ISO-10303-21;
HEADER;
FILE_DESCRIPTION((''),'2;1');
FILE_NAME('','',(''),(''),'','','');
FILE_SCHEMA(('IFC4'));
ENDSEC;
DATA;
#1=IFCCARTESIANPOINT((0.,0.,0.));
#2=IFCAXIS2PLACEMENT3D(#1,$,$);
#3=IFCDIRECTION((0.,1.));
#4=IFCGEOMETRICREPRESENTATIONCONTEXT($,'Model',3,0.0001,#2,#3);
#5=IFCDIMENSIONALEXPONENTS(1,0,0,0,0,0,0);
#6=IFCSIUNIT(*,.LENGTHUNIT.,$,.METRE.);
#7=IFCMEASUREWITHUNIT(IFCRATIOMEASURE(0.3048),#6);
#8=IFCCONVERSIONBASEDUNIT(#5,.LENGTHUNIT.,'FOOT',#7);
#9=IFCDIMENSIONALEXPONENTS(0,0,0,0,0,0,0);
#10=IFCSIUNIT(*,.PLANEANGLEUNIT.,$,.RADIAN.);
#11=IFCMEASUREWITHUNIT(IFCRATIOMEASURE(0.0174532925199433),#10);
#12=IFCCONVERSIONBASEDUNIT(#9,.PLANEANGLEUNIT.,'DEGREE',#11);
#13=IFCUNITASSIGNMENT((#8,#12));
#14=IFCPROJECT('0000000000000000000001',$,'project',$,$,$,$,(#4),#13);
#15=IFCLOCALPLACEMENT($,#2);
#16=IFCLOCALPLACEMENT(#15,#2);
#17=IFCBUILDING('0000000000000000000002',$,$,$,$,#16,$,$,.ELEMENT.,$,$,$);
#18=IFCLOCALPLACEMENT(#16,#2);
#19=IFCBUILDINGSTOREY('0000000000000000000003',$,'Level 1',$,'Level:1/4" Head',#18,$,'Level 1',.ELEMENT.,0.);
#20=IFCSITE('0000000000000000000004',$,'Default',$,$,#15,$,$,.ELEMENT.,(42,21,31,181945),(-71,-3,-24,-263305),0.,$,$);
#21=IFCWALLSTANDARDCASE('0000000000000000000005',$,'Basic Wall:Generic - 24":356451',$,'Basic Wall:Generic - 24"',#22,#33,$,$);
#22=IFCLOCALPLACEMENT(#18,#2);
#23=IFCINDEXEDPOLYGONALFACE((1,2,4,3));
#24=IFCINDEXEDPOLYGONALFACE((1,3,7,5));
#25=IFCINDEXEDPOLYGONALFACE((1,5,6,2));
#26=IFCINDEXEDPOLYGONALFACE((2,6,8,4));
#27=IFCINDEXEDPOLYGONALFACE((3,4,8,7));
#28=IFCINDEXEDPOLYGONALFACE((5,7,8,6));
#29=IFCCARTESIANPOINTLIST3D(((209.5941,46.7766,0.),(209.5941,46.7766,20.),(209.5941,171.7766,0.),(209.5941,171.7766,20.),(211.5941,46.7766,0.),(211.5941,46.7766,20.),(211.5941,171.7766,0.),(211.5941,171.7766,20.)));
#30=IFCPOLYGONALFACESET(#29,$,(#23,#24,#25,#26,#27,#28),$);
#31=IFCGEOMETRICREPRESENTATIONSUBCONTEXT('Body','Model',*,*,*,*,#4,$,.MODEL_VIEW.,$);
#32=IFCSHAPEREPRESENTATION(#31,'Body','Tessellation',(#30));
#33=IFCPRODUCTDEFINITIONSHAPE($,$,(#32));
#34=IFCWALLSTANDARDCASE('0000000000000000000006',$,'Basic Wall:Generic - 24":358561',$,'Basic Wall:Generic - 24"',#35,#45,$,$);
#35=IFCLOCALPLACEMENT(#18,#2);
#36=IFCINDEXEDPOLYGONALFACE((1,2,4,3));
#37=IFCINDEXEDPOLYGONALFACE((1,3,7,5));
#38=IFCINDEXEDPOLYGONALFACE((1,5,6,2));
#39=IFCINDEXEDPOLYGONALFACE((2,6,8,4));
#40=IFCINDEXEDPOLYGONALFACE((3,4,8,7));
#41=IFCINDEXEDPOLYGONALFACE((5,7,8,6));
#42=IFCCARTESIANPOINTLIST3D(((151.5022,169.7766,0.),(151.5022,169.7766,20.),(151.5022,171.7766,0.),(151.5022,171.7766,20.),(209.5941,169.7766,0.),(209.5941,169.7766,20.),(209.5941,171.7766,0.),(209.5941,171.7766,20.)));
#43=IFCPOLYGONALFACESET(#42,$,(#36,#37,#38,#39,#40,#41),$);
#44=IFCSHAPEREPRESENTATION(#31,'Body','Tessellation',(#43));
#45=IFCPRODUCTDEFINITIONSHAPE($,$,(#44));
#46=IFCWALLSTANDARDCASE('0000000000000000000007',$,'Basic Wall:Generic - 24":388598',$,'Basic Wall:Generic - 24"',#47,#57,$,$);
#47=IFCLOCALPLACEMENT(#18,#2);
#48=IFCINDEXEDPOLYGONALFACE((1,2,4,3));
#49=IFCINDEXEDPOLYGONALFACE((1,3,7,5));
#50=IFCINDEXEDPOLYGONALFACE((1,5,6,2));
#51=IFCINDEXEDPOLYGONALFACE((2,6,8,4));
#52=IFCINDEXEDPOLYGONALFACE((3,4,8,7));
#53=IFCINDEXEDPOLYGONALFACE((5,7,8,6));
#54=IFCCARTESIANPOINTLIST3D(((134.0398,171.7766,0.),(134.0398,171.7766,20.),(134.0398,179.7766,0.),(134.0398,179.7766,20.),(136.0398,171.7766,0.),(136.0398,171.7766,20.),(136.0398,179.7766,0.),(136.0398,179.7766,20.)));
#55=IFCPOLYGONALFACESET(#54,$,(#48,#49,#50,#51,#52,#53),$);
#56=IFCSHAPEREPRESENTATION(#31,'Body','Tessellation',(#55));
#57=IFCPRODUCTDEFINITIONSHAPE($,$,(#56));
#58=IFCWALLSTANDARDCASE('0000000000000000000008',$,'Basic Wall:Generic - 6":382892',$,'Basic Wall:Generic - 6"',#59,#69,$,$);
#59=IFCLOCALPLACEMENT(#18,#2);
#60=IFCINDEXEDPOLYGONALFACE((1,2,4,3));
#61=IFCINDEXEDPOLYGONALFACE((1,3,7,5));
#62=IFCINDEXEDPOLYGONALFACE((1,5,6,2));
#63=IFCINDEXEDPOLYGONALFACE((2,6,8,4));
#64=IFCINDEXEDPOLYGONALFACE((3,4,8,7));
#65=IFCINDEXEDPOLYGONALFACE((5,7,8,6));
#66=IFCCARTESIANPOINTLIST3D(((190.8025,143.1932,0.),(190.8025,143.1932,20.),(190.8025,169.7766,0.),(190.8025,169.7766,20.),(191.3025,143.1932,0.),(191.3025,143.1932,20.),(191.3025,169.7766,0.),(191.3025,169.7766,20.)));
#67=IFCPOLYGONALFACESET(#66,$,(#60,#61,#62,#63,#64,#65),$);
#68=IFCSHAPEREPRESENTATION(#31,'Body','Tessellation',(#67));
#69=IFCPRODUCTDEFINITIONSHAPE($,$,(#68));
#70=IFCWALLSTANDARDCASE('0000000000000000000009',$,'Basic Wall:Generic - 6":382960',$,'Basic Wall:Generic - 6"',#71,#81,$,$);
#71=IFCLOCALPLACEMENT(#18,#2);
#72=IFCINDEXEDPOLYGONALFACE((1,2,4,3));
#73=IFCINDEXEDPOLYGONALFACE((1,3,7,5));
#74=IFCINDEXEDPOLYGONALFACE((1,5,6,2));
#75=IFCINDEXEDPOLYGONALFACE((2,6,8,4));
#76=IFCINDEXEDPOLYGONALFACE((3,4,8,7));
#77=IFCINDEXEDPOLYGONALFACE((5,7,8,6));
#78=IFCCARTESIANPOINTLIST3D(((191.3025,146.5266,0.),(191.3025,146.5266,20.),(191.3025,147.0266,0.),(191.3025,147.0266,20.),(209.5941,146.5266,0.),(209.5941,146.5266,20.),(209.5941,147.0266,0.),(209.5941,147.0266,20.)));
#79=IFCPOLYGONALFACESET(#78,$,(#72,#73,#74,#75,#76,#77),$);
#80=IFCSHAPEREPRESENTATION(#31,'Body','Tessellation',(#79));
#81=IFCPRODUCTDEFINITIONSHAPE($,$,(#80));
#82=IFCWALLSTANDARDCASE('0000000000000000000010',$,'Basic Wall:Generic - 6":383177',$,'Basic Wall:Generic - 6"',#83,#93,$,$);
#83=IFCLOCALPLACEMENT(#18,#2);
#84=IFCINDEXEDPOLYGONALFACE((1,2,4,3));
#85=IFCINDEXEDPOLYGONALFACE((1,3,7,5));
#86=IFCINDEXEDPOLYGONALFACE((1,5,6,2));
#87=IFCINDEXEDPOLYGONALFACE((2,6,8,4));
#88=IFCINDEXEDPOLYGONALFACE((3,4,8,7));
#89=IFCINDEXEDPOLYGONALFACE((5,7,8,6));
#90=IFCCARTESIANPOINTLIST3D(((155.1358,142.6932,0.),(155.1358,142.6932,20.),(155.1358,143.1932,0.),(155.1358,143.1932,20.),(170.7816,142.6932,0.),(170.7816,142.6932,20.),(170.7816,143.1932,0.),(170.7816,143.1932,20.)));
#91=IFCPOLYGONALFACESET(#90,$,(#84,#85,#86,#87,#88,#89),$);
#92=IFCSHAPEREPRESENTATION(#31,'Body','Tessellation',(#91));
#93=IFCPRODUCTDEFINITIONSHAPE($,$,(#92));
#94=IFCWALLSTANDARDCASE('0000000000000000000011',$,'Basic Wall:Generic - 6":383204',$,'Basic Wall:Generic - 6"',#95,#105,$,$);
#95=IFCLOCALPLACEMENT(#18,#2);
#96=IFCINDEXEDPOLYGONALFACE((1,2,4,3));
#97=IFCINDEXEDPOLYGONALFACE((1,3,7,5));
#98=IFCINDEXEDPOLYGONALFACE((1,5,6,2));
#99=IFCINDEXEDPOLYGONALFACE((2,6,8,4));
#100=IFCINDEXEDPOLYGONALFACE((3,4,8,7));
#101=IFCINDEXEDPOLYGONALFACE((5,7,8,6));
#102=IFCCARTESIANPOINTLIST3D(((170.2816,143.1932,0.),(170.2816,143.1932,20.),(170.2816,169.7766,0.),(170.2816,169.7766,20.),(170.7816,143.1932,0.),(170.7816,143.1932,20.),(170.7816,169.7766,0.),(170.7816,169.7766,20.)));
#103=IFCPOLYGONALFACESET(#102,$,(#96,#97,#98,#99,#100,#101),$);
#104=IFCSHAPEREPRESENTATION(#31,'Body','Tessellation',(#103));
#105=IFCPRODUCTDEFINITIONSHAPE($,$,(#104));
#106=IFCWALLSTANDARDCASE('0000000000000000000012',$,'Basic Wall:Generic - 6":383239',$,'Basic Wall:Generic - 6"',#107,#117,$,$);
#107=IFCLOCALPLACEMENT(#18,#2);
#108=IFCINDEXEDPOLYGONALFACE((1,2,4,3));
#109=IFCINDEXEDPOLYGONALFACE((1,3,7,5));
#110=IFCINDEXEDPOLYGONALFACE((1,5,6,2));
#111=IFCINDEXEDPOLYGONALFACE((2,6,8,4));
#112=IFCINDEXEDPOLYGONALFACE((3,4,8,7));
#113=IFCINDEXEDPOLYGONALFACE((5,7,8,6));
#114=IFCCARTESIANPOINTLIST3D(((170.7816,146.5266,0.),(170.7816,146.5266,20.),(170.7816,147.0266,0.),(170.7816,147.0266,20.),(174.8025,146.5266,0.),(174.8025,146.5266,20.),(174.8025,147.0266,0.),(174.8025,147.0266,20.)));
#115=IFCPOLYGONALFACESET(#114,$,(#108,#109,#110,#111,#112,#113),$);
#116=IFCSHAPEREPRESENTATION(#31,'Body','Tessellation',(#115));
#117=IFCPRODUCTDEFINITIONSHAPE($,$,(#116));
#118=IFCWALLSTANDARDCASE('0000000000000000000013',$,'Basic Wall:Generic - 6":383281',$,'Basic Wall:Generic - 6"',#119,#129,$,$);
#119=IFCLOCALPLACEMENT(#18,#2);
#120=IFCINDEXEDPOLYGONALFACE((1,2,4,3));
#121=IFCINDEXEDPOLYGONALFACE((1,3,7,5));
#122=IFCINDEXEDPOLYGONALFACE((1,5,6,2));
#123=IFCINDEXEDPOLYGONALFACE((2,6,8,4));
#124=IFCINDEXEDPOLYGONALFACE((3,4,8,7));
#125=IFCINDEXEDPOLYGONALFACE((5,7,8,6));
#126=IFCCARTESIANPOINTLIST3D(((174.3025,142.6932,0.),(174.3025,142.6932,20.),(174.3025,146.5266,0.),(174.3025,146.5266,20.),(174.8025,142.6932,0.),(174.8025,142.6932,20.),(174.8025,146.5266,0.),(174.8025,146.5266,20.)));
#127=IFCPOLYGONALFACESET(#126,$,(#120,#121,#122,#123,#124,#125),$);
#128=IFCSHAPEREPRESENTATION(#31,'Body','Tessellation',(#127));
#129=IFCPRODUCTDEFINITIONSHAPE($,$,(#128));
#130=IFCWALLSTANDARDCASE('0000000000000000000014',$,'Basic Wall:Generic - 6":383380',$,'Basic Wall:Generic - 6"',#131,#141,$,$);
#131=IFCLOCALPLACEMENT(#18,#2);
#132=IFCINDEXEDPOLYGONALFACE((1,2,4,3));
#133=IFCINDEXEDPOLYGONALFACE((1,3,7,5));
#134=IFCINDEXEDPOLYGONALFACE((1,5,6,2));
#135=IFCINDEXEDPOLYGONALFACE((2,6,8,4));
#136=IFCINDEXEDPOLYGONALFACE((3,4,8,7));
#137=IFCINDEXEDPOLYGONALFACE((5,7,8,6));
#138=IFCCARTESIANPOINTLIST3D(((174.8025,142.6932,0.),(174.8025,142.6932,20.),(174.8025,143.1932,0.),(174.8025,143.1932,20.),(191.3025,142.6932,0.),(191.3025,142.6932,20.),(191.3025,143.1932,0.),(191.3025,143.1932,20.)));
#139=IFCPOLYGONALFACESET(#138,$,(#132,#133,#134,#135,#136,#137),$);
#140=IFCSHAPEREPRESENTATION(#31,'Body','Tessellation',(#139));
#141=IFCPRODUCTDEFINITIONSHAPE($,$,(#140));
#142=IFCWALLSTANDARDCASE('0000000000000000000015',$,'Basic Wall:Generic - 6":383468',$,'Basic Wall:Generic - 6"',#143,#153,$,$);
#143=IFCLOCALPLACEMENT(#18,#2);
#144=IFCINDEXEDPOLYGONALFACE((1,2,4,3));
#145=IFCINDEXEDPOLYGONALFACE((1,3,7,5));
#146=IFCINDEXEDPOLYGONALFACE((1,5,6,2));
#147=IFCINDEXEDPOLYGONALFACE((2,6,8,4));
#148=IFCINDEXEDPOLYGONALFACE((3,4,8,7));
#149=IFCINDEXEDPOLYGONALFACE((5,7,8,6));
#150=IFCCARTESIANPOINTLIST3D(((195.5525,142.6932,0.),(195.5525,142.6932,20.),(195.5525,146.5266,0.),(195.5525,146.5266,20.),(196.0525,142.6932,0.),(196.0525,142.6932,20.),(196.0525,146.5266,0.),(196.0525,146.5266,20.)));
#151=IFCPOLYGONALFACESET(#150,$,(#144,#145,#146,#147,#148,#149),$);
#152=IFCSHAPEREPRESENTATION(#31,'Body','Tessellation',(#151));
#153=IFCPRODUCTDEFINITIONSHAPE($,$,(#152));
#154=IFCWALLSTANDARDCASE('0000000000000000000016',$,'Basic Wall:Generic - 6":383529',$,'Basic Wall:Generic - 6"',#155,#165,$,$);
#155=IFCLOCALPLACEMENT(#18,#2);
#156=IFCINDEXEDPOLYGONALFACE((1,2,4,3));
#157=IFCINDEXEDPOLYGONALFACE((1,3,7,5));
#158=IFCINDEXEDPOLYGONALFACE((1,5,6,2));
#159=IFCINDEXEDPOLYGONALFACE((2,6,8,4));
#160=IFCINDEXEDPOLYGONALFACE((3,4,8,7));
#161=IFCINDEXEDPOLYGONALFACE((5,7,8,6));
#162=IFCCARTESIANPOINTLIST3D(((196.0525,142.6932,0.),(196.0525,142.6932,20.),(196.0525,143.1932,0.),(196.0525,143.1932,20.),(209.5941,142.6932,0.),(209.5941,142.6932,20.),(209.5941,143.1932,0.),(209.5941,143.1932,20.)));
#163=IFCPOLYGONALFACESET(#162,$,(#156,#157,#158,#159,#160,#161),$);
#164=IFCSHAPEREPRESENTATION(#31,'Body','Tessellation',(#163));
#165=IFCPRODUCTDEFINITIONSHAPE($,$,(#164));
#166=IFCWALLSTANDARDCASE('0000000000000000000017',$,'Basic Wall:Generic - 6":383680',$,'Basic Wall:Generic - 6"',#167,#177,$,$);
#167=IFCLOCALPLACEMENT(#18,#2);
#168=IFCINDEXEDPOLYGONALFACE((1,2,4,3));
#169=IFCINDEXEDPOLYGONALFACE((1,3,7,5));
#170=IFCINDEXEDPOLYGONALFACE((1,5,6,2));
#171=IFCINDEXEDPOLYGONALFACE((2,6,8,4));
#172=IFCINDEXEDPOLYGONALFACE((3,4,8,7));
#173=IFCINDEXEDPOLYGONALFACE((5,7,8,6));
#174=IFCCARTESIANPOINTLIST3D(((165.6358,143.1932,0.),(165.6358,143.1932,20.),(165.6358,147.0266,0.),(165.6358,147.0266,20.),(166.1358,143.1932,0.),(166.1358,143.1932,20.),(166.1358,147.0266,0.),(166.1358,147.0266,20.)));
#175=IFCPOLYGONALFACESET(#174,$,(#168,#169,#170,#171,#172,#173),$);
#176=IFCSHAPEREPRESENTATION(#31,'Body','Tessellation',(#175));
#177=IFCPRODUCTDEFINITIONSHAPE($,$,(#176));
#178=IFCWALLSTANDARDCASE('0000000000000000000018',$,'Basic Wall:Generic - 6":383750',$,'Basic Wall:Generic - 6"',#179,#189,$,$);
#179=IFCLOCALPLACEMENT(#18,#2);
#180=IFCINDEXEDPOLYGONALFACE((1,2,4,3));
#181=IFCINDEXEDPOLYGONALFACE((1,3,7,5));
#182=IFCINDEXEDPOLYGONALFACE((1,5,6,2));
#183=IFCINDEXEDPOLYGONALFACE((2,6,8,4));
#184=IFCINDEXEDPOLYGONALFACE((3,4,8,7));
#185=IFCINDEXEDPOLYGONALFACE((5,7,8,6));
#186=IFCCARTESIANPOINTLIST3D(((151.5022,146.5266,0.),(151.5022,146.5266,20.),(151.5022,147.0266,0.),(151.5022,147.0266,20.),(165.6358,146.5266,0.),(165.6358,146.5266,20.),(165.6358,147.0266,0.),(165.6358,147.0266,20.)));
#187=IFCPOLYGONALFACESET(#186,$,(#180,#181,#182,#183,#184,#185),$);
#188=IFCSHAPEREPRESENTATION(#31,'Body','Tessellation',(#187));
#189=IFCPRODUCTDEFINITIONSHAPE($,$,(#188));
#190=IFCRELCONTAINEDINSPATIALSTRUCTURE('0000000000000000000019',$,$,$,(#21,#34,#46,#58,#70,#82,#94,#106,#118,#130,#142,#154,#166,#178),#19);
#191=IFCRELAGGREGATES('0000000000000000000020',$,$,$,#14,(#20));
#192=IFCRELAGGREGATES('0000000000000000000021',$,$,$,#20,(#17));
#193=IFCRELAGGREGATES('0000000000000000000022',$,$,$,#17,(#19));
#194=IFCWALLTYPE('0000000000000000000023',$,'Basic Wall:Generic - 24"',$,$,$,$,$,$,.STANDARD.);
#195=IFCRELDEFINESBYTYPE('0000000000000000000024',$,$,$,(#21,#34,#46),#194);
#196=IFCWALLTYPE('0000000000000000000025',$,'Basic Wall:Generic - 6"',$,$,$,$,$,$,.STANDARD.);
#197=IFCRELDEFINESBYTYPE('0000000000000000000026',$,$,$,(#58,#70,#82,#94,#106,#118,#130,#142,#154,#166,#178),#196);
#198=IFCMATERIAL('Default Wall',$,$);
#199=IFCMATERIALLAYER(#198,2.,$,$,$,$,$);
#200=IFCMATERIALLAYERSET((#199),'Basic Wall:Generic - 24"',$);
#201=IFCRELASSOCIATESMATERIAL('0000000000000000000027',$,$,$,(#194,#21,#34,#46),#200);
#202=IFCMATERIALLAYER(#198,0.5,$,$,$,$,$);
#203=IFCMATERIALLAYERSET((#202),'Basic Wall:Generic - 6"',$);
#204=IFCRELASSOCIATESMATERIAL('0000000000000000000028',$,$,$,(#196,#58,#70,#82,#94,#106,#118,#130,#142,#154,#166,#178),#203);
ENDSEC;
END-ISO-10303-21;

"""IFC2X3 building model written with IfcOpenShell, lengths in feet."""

from ifc_helpers import new_model, entity, si_unit, converted_unit, direction, frame, frame_2d, origin, place, context, subcontext, project, spatial, rectangle, extrude, material, layer, layer_set, layer_usage, type_object, element, save


model = new_model("IFC2X3")

# Units and contexts
model_context = context("Model", 3, precision=0.0001, world=origin(), true_north=direction((0.0, 1.0)))
body_context = subcontext(model_context, "Body", "Model", "MODEL_VIEW")
ifc_project = project(units=[converted_unit("LENGTHUNIT", "FOOT", entity("IfcRatioMeasure", 0.3048), si_unit("LENGTHUNIT", "METRE"), dimensions=[1, 0, 0, 0, 0, 0, 0]), converted_unit("PLANEANGLEUNIT", "DEGREE", entity("IfcRatioMeasure", 0.0174532925199433), si_unit("PLANEANGLEUNIT", "RADIAN"), dimensions=[0, 0, 0, 0, 0, 0, 0])], contexts=[model_context])

# Site, building, storey
site_placement = place(None, origin())
site = spatial("IfcSite", under=ifc_project, at=site_placement, Name="Default", CompositionType="ELEMENT", RefLatitude=(42, 21, 31, 181945), RefLongitude=(-71, -3, -24, -263305), RefElevation=0.0)
building_placement = place(site_placement, origin())
building = spatial("IfcBuilding", under=site, at=building_placement, CompositionType="ELEMENT")
storey_placement = place(building_placement, origin())
storey = spatial("IfcBuildingStorey", under=building, at=storey_placement, Name="Level 1", ObjectType="Level:1/4\" Head", LongName="Level 1", CompositionType="ELEMENT", Elevation=0.0)

# Walls
ifc_material = material(Name="Default Wall")
ifc_layer_1 = layer(ifc_material, 2.0)
ifc_layer_set_1 = layer_set([ifc_layer_1], Name="Basic Wall:Generic - 24\"")
ifc_layer_usage_1 = layer_usage(ifc_layer_set_1, "AXIS2", "NEGATIVE", 1.0)
wall_type_1 = type_object("IfcWallType", Name="Basic Wall:Generic - 24\"", PredefinedType="STANDARD", material=ifc_layer_set_1)
wall_1_placement = place(storey_placement, frame((210.5941, 171.7766, 0.0), z_axis=(0.0, 0.0, 1.0), x_axis=(0.0, -1.0, 0.0)))
element("IfcWallStandardCase", 1, at=wall_1_placement, inside=storey, type_object=wall_type_1, material=ifc_layer_usage_1, Name="Basic Wall:Generic - 24\":356451", ObjectType="Basic Wall:Generic - 24\"", context=body_context, shape_type="SweptSolid", body=[
    extrude(rectangle(XDim=125.0, YDim=2.0, at=frame_2d((62.5, 0.0), x_axis=(-1.0, 0.0))), origin(), (0.0, 0.0, 1.0), 20.0),
])
ifc_layer_usage_2 = layer_usage(ifc_layer_set_1, "AXIS2", "NEGATIVE", 1.0)
wall_2_placement = place(storey_placement, frame((209.5941, 170.7766, 0.0), z_axis=(0.0, 0.0, 1.0), x_axis=(-1.0, 0.0, 0.0)))
element("IfcWallStandardCase", 2, at=wall_2_placement, inside=storey, type_object=wall_type_1, material=ifc_layer_usage_2, Name="Basic Wall:Generic - 24\":358561", ObjectType="Basic Wall:Generic - 24\"", context=body_context, shape_type="SweptSolid", body=[
    extrude(rectangle(XDim=58.092, YDim=2.0, at=frame_2d((29.046, 0.0), x_axis=(-1.0, 0.0))), origin(), (0.0, 0.0, 1.0), 20.0),
])
ifc_layer_usage_3 = layer_usage(ifc_layer_set_1, "AXIS2", "NEGATIVE", 1.0)
wall_3_placement = place(storey_placement, frame((135.0398, 179.7766, 0.0), z_axis=(0.0, 0.0, 1.0), x_axis=(0.0, -1.0, 0.0)))
element("IfcWallStandardCase", 3, at=wall_3_placement, inside=storey, type_object=wall_type_1, material=ifc_layer_usage_3, Name="Basic Wall:Generic - 24\":388598", ObjectType="Basic Wall:Generic - 24\"", context=body_context, shape_type="SweptSolid", body=[
    extrude(rectangle(XDim=8.0, YDim=2.0, at=frame_2d((4.0, 0.0), x_axis=(-1.0, 0.0))), origin(), (0.0, 0.0, 1.0), 20.0),
])
ifc_layer_2 = layer(ifc_material, 0.5)
ifc_layer_set_2 = layer_set([ifc_layer_2], Name="Basic Wall:Generic - 6\"")
ifc_layer_usage_4 = layer_usage(ifc_layer_set_2, "AXIS2", "NEGATIVE", 0.25)
wall_type_2 = type_object("IfcWallType", Name="Basic Wall:Generic - 6\"", PredefinedType="STANDARD", material=ifc_layer_set_2)
wall_4_placement = place(storey_placement, frame((191.0525, 169.7766, 0.0), z_axis=(0.0, 0.0, 1.0), x_axis=(0.0, -1.0, 0.0)))
element("IfcWallStandardCase", 4, at=wall_4_placement, inside=storey, type_object=wall_type_2, material=ifc_layer_usage_4, Name="Basic Wall:Generic - 6\":382892", ObjectType="Basic Wall:Generic - 6\"", context=body_context, shape_type="SweptSolid", body=[
    extrude(rectangle(XDim=26.5833, YDim=0.5, at=frame_2d((13.2917, 0.0), x_axis=(-1.0, 0.0))), origin(), (0.0, 0.0, 1.0), 20.0),
])
ifc_layer_usage_5 = layer_usage(ifc_layer_set_2, "AXIS2", "NEGATIVE", 0.25)
wall_5_placement = place(storey_placement, frame((191.3025, 146.7766, 0.0)))
element("IfcWallStandardCase", 5, at=wall_5_placement, inside=storey, type_object=wall_type_2, material=ifc_layer_usage_5, Name="Basic Wall:Generic - 6\":382960", ObjectType="Basic Wall:Generic - 6\"", context=body_context, shape_type="SweptSolid", body=[
    extrude(rectangle(XDim=18.2917, YDim=0.5, at=frame_2d((9.1458, 0.0), x_axis=(-1.0, 0.0))), origin(), (0.0, 0.0, 1.0), 20.0),
])
ifc_layer_usage_6 = layer_usage(ifc_layer_set_2, "AXIS2", "NEGATIVE", 0.25)
wall_6_placement = place(storey_placement, frame((155.1358, 142.9432, 0.0)))
element("IfcWallStandardCase", 6, at=wall_6_placement, inside=storey, type_object=wall_type_2, material=ifc_layer_usage_6, Name="Basic Wall:Generic - 6\":383177", ObjectType="Basic Wall:Generic - 6\"", context=body_context, shape_type="SweptSolid", body=[
    extrude(rectangle(XDim=15.6458, YDim=0.5, at=frame_2d((7.8229, 0.0), x_axis=(-1.0, 0.0))), origin(), (0.0, 0.0, 1.0), 20.0),
])
ifc_layer_usage_7 = layer_usage(ifc_layer_set_2, "AXIS2", "NEGATIVE", 0.25)
wall_7_placement = place(storey_placement, frame((170.5316, 143.1932, 0.0), z_axis=(0.0, 0.0, 1.0), x_axis=(0.0, 1.0, 0.0)))
element("IfcWallStandardCase", 7, at=wall_7_placement, inside=storey, type_object=wall_type_2, material=ifc_layer_usage_7, Name="Basic Wall:Generic - 6\":383204", ObjectType="Basic Wall:Generic - 6\"", context=body_context, shape_type="SweptSolid", body=[
    extrude(rectangle(XDim=26.5833, YDim=0.5, at=frame_2d((13.2917, 0.0), x_axis=(-1.0, 0.0))), origin(), (0.0, 0.0, 1.0), 20.0),
])
ifc_layer_usage_8 = layer_usage(ifc_layer_set_2, "AXIS2", "NEGATIVE", 0.25)
wall_8_placement = place(storey_placement, frame((170.7816, 146.7766, 0.0)))
element("IfcWallStandardCase", 8, at=wall_8_placement, inside=storey, type_object=wall_type_2, material=ifc_layer_usage_8, Name="Basic Wall:Generic - 6\":383239", ObjectType="Basic Wall:Generic - 6\"", context=body_context, shape_type="SweptSolid", body=[
    extrude(rectangle(XDim=4.0208, YDim=0.5, at=frame_2d((2.0104, 0.0), x_axis=(-1.0, 0.0))), origin(), (0.0, 0.0, 1.0), 20.0),
])
ifc_layer_usage_9 = layer_usage(ifc_layer_set_2, "AXIS2", "NEGATIVE", 0.25)
wall_9_placement = place(storey_placement, frame((174.5525, 146.5266, 0.0), z_axis=(0.0, 0.0, 1.0), x_axis=(0.0, -1.0, 0.0)))
element("IfcWallStandardCase", 9, at=wall_9_placement, inside=storey, type_object=wall_type_2, material=ifc_layer_usage_9, Name="Basic Wall:Generic - 6\":383281", ObjectType="Basic Wall:Generic - 6\"", context=body_context, shape_type="SweptSolid", body=[
    extrude(rectangle(XDim=3.8333, YDim=0.5, at=frame_2d((1.9167, 0.0), x_axis=(-1.0, 0.0))), origin(), (0.0, 0.0, 1.0), 20.0),
])
ifc_layer_usage_10 = layer_usage(ifc_layer_set_2, "AXIS2", "NEGATIVE", 0.25)
wall_10_placement = place(storey_placement, frame((174.8025, 142.9432, 0.0)))
element("IfcWallStandardCase", 10, at=wall_10_placement, inside=storey, type_object=wall_type_2, material=ifc_layer_usage_10, Name="Basic Wall:Generic - 6\":383380", ObjectType="Basic Wall:Generic - 6\"", context=body_context, shape_type="SweptSolid", body=[
    extrude(rectangle(XDim=16.5, YDim=0.5, at=frame_2d((8.25, 0.0), x_axis=(-1.0, 0.0))), origin(), (0.0, 0.0, 1.0), 20.0),
])
ifc_layer_usage_11 = layer_usage(ifc_layer_set_2, "AXIS2", "NEGATIVE", 0.25)
wall_11_placement = place(storey_placement, frame((195.8025, 146.5266, 0.0), z_axis=(0.0, 0.0, 1.0), x_axis=(0.0, -1.0, 0.0)))
element("IfcWallStandardCase", 11, at=wall_11_placement, inside=storey, type_object=wall_type_2, material=ifc_layer_usage_11, Name="Basic Wall:Generic - 6\":383468", ObjectType="Basic Wall:Generic - 6\"", context=body_context, shape_type="SweptSolid", body=[
    extrude(rectangle(XDim=3.8333, YDim=0.5, at=frame_2d((1.9167, 0.0), x_axis=(-1.0, 0.0))), origin(), (0.0, 0.0, 1.0), 20.0),
])
ifc_layer_usage_12 = layer_usage(ifc_layer_set_2, "AXIS2", "NEGATIVE", 0.25)
wall_12_placement = place(storey_placement, frame((196.0525, 142.9432, 0.0)))
element("IfcWallStandardCase", 12, at=wall_12_placement, inside=storey, type_object=wall_type_2, material=ifc_layer_usage_12, Name="Basic Wall:Generic - 6\":383529", ObjectType="Basic Wall:Generic - 6\"", context=body_context, shape_type="SweptSolid", body=[
    extrude(rectangle(XDim=13.5417, YDim=0.5, at=frame_2d((6.7708, 0.0), x_axis=(-1.0, 0.0))), origin(), (0.0, 0.0, 1.0), 20.0),
])
ifc_layer_usage_13 = layer_usage(ifc_layer_set_2, "AXIS2", "NEGATIVE", 0.25)
wall_13_placement = place(storey_placement, frame((165.8858, 143.1932, 0.0), z_axis=(0.0, 0.0, 1.0), x_axis=(0.0, 1.0, 0.0)))
element("IfcWallStandardCase", 13, at=wall_13_placement, inside=storey, type_object=wall_type_2, material=ifc_layer_usage_13, Name="Basic Wall:Generic - 6\":383680", ObjectType="Basic Wall:Generic - 6\"", context=body_context, shape_type="SweptSolid", body=[
    extrude(rectangle(XDim=3.8333, YDim=0.5, at=frame_2d((1.9167, 0.0), x_axis=(-1.0, 0.0))), origin(), (0.0, 0.0, 1.0), 20.0),
])
ifc_layer_usage_14 = layer_usage(ifc_layer_set_2, "AXIS2", "NEGATIVE", 0.25)
wall_14_placement = place(storey_placement, frame((165.6358, 146.7766, 0.0), z_axis=(0.0, 0.0, 1.0), x_axis=(-1.0, 0.0, 0.0)))
element("IfcWallStandardCase", 14, at=wall_14_placement, inside=storey, type_object=wall_type_2, material=ifc_layer_usage_14, Name="Basic Wall:Generic - 6\":383750", ObjectType="Basic Wall:Generic - 6\"", context=body_context, shape_type="SweptSolid", body=[
    extrude(rectangle(XDim=14.1336, YDim=0.5, at=frame_2d((7.0668, 0.0), x_axis=(-1.0, 0.0))), origin(), (0.0, 0.0, 1.0), 20.0),
])

save(model, "model.ifc")
